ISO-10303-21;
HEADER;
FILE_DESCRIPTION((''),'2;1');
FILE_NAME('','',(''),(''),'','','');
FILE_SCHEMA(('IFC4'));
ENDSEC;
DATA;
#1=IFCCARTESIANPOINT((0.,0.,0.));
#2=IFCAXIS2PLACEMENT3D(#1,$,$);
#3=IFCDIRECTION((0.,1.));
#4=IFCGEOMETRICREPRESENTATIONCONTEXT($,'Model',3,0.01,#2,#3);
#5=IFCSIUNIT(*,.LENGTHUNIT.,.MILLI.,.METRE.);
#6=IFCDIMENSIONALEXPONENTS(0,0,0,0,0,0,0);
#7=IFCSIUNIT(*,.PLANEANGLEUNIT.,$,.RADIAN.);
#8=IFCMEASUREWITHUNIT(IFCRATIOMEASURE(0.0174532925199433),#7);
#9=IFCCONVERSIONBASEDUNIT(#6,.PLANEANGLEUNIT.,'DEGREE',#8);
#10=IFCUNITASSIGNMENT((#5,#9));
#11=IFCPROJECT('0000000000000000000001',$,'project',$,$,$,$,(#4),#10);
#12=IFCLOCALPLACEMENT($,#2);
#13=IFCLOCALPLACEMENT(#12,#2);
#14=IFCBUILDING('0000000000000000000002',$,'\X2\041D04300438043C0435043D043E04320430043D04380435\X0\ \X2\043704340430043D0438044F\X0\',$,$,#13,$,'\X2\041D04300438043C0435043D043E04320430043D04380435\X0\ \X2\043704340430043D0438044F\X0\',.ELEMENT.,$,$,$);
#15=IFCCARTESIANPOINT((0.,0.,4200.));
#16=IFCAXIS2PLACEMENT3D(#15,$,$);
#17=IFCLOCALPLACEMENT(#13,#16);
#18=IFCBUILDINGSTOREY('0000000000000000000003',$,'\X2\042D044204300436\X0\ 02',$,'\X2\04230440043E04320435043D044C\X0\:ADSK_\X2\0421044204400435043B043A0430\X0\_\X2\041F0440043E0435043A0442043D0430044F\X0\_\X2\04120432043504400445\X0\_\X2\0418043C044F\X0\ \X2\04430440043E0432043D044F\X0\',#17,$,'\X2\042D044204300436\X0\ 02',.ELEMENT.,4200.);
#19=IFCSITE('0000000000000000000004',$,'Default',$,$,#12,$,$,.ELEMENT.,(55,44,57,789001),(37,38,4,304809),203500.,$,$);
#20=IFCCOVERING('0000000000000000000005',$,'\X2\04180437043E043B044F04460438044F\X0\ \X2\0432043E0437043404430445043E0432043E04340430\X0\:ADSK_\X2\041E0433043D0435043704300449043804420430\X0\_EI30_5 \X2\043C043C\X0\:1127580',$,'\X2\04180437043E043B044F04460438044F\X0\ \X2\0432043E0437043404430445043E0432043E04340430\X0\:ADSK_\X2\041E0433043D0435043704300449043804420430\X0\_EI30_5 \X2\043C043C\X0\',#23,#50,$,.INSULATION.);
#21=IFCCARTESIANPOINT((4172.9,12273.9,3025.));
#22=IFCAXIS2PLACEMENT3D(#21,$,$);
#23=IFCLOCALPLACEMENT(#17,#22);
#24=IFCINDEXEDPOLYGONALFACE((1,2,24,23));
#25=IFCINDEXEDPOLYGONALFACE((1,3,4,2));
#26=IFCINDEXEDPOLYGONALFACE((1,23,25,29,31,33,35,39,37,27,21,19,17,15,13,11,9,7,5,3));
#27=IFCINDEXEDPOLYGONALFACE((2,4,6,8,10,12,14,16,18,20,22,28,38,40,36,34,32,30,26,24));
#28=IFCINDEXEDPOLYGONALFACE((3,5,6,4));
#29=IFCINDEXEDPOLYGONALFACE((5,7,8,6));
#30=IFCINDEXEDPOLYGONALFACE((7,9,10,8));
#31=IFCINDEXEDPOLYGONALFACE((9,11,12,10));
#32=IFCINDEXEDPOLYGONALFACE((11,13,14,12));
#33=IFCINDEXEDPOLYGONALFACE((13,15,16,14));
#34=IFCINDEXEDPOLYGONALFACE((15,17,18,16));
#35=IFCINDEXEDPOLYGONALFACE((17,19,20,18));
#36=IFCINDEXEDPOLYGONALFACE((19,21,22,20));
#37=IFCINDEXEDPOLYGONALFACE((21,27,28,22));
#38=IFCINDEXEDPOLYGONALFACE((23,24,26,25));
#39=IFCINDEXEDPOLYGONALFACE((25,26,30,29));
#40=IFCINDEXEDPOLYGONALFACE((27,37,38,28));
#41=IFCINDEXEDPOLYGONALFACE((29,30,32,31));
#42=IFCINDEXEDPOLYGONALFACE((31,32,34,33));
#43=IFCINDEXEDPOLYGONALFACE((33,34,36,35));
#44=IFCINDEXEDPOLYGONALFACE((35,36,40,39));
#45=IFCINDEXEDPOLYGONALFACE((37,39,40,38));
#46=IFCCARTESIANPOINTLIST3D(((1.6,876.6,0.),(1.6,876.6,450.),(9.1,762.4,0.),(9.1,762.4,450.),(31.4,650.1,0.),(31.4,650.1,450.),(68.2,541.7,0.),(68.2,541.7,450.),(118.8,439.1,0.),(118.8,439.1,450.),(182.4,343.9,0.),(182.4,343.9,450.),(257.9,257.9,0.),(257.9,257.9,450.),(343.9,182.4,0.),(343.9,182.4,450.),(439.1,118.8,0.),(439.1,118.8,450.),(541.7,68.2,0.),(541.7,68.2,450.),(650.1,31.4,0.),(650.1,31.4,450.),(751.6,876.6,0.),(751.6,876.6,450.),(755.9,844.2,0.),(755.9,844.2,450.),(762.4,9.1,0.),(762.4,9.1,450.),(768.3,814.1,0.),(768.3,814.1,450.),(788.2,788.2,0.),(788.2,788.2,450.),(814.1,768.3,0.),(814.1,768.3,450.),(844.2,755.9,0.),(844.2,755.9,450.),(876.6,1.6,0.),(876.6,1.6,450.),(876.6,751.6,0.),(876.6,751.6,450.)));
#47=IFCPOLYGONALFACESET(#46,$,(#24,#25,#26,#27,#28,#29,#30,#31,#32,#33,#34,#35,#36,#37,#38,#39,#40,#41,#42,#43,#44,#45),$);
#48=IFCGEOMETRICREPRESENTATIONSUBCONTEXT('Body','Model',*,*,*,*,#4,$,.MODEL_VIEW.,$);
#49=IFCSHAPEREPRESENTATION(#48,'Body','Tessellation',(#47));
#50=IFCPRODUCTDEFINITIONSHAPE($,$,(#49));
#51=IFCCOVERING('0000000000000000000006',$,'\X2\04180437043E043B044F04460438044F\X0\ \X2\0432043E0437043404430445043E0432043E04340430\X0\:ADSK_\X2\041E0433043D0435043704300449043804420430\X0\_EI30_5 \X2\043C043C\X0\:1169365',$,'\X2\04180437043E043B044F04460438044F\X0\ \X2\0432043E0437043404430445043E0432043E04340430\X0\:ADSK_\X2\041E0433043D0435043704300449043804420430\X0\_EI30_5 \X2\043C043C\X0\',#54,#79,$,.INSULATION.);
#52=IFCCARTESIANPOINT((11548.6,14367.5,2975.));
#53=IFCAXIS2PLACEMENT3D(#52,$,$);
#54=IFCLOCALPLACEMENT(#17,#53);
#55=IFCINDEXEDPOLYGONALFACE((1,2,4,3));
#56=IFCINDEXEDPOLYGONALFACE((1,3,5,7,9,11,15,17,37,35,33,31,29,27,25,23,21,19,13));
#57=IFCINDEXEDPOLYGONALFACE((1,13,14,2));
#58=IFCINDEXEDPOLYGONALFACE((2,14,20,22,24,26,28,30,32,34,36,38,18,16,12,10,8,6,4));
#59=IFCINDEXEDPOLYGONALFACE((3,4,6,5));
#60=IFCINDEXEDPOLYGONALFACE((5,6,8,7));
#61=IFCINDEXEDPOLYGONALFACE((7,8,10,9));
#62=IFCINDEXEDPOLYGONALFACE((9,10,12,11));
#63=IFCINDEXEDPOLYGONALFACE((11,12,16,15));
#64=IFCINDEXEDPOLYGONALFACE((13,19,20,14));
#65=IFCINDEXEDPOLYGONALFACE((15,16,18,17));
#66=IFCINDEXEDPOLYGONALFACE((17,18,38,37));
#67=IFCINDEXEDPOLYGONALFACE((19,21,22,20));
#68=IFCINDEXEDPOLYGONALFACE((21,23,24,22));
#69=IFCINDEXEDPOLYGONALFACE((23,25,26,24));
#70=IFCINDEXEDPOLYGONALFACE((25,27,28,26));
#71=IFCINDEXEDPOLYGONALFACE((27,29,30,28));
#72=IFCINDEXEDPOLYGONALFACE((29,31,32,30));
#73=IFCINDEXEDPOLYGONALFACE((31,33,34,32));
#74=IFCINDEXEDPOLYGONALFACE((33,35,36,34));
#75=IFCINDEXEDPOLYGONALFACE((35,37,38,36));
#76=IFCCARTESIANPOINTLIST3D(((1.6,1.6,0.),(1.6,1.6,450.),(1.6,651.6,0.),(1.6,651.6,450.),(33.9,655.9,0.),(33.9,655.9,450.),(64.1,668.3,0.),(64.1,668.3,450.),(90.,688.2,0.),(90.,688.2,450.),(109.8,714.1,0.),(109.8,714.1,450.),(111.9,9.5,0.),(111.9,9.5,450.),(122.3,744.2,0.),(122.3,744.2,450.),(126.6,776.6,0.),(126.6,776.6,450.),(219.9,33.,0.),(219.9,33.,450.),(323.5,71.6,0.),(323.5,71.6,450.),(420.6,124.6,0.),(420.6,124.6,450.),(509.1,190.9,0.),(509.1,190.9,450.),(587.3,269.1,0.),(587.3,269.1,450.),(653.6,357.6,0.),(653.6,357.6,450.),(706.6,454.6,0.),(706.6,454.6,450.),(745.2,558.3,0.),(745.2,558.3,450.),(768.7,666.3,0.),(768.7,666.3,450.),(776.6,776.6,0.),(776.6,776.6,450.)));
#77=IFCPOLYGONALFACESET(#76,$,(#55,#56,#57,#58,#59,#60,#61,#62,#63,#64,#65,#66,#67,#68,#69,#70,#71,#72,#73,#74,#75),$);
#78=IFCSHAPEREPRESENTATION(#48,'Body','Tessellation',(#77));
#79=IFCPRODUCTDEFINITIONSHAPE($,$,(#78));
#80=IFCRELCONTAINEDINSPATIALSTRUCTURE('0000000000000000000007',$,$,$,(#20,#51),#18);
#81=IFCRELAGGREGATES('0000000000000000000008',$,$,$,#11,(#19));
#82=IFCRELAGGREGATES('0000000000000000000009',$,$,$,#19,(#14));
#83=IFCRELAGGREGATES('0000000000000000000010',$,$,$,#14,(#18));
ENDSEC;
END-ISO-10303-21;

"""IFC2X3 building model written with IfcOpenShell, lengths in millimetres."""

from ifc_helpers import new_model, entity, si_unit, converted_unit, direction, frame, frame_2d, origin, place, context, subcontext, project, spatial, polyline, circle_curve, parameter, trimmed, segment, composite_curve, outline, extrude, element, save


model = new_model("IFC2X3")

# Units and contexts
model_context = context("Model", 3, precision=0.01, world=origin(), true_north=direction((0.0, 1.0)))
body_context = subcontext(model_context, "Body", "Model", "MODEL_VIEW")
ifc_project = project(units=[si_unit("LENGTHUNIT", "METRE", prefix="MILLI"), converted_unit("PLANEANGLEUNIT", "DEGREE", entity("IfcRatioMeasure", 0.0174532925199433), si_unit("PLANEANGLEUNIT", "RADIAN"), dimensions=[0, 0, 0, 0, 0, 0, 0])], contexts=[model_context])

# Site, building, storey
site_placement = place(None, frame((0.0, 0.0, 0.0)))
site = spatial("IfcSite", under=ifc_project, at=site_placement, Name="Default", CompositionType="ELEMENT", RefLatitude=(55, 44, 57, 789001), RefLongitude=(37, 38, 4, 304809), RefElevation=203500.0)
building_placement = place(site_placement, origin())
building = spatial("IfcBuilding", under=site, at=building_placement, Name="Наименование здания", LongName="Наименование здания", CompositionType="ELEMENT")
storey_placement = place(building_placement, frame((0.0, 0.0, 4200.0)))
storey = spatial("IfcBuildingStorey", under=building, at=storey_placement, Name="Этаж 02", ObjectType="Уровень:ADSK_Стрелка_Проектная_Вверх_Имя уровня", LongName="Этаж 02", CompositionType="ELEMENT", Elevation=4200.0)

# Coverings
covering_1_placement = place(storey_placement, frame((4172.9, 12273.9, 3025.0)))
element("IfcCovering", 1, at=covering_1_placement, inside=storey, Name="Изоляция воздуховода:ADSK_Огнезащита_EI30_5 мм:1127580", ObjectType="Изоляция воздуховода:ADSK_Огнезащита_EI30_5 мм", PredefinedType="INSULATION", context=body_context, shape_type="SweptSolid", body=[
    extrude(outline(composite_curve([segment(polyline([(-250.0, 125.0), (-250.0, -625.0)]), True, "CONTINUOUS"), segment(trimmed(circle_curve(frame_2d((-250.0, 250.0), x_axis=(1.0, 0.0)), 875.0), [parameter(270.0)], [parameter(0.0)], True, "PARAMETER"), True, "CONTINUOUS"), segment(polyline([(625.0, 250.0), (-125.0, 250.0)]), True, "CONTINUOUS"), segment(trimmed(circle_curve(frame_2d((-250.0, 250.0), x_axis=(1.0, 0.0)), 125.0), [parameter(270.0)], [parameter(360.0)], True, "PARAMETER"), False, "CONTINUOUS")], self_intersect=False)), frame((626.6, 626.6, 0.0), z_axis=(0.0, 0.0, -1.0), x_axis=(-1.0, 0.0, 0.0)), (0.0, 0.0, -1.0), 450.0),
])
covering_2_placement = place(storey_placement, frame((11548.6, 14367.5, 2975.0)))
element("IfcCovering", 2, at=covering_2_placement, inside=storey, Name="Изоляция воздуховода:ADSK_Огнезащита_EI30_5 мм:1169365", ObjectType="Изоляция воздуховода:ADSK_Огнезащита_EI30_5 мм", PredefinedType="INSULATION", context=body_context, shape_type="SweptSolid", body=[
    extrude(outline(composite_curve([segment(polyline([(-225.0, 100.0), (-225.0, -550.0)]), True, "CONTINUOUS"), segment(trimmed(circle_curve(frame_2d((-225.0, 225.0), x_axis=(1.0, 0.0)), 775.0), [parameter(270.0)], [parameter(0.0)], True, "PARAMETER"), True, "CONTINUOUS"), segment(polyline([(550.0, 225.0), (-100.0, 225.0)]), True, "CONTINUOUS"), segment(trimmed(circle_curve(frame_2d((-225.0, 225.0), x_axis=(1.0, 0.0)), 125.0), [parameter(270.0)], [parameter(360.0)], True, "PARAMETER"), False, "CONTINUOUS")], self_intersect=False)), frame((226.6, 551.6, 0.0), z_axis=(0.0, 0.0, -1.0), x_axis=(0.0, -1.0, 0.0)), (0.0, 0.0, -1.0), 450.0),
])

save(model, "model.ifc")
